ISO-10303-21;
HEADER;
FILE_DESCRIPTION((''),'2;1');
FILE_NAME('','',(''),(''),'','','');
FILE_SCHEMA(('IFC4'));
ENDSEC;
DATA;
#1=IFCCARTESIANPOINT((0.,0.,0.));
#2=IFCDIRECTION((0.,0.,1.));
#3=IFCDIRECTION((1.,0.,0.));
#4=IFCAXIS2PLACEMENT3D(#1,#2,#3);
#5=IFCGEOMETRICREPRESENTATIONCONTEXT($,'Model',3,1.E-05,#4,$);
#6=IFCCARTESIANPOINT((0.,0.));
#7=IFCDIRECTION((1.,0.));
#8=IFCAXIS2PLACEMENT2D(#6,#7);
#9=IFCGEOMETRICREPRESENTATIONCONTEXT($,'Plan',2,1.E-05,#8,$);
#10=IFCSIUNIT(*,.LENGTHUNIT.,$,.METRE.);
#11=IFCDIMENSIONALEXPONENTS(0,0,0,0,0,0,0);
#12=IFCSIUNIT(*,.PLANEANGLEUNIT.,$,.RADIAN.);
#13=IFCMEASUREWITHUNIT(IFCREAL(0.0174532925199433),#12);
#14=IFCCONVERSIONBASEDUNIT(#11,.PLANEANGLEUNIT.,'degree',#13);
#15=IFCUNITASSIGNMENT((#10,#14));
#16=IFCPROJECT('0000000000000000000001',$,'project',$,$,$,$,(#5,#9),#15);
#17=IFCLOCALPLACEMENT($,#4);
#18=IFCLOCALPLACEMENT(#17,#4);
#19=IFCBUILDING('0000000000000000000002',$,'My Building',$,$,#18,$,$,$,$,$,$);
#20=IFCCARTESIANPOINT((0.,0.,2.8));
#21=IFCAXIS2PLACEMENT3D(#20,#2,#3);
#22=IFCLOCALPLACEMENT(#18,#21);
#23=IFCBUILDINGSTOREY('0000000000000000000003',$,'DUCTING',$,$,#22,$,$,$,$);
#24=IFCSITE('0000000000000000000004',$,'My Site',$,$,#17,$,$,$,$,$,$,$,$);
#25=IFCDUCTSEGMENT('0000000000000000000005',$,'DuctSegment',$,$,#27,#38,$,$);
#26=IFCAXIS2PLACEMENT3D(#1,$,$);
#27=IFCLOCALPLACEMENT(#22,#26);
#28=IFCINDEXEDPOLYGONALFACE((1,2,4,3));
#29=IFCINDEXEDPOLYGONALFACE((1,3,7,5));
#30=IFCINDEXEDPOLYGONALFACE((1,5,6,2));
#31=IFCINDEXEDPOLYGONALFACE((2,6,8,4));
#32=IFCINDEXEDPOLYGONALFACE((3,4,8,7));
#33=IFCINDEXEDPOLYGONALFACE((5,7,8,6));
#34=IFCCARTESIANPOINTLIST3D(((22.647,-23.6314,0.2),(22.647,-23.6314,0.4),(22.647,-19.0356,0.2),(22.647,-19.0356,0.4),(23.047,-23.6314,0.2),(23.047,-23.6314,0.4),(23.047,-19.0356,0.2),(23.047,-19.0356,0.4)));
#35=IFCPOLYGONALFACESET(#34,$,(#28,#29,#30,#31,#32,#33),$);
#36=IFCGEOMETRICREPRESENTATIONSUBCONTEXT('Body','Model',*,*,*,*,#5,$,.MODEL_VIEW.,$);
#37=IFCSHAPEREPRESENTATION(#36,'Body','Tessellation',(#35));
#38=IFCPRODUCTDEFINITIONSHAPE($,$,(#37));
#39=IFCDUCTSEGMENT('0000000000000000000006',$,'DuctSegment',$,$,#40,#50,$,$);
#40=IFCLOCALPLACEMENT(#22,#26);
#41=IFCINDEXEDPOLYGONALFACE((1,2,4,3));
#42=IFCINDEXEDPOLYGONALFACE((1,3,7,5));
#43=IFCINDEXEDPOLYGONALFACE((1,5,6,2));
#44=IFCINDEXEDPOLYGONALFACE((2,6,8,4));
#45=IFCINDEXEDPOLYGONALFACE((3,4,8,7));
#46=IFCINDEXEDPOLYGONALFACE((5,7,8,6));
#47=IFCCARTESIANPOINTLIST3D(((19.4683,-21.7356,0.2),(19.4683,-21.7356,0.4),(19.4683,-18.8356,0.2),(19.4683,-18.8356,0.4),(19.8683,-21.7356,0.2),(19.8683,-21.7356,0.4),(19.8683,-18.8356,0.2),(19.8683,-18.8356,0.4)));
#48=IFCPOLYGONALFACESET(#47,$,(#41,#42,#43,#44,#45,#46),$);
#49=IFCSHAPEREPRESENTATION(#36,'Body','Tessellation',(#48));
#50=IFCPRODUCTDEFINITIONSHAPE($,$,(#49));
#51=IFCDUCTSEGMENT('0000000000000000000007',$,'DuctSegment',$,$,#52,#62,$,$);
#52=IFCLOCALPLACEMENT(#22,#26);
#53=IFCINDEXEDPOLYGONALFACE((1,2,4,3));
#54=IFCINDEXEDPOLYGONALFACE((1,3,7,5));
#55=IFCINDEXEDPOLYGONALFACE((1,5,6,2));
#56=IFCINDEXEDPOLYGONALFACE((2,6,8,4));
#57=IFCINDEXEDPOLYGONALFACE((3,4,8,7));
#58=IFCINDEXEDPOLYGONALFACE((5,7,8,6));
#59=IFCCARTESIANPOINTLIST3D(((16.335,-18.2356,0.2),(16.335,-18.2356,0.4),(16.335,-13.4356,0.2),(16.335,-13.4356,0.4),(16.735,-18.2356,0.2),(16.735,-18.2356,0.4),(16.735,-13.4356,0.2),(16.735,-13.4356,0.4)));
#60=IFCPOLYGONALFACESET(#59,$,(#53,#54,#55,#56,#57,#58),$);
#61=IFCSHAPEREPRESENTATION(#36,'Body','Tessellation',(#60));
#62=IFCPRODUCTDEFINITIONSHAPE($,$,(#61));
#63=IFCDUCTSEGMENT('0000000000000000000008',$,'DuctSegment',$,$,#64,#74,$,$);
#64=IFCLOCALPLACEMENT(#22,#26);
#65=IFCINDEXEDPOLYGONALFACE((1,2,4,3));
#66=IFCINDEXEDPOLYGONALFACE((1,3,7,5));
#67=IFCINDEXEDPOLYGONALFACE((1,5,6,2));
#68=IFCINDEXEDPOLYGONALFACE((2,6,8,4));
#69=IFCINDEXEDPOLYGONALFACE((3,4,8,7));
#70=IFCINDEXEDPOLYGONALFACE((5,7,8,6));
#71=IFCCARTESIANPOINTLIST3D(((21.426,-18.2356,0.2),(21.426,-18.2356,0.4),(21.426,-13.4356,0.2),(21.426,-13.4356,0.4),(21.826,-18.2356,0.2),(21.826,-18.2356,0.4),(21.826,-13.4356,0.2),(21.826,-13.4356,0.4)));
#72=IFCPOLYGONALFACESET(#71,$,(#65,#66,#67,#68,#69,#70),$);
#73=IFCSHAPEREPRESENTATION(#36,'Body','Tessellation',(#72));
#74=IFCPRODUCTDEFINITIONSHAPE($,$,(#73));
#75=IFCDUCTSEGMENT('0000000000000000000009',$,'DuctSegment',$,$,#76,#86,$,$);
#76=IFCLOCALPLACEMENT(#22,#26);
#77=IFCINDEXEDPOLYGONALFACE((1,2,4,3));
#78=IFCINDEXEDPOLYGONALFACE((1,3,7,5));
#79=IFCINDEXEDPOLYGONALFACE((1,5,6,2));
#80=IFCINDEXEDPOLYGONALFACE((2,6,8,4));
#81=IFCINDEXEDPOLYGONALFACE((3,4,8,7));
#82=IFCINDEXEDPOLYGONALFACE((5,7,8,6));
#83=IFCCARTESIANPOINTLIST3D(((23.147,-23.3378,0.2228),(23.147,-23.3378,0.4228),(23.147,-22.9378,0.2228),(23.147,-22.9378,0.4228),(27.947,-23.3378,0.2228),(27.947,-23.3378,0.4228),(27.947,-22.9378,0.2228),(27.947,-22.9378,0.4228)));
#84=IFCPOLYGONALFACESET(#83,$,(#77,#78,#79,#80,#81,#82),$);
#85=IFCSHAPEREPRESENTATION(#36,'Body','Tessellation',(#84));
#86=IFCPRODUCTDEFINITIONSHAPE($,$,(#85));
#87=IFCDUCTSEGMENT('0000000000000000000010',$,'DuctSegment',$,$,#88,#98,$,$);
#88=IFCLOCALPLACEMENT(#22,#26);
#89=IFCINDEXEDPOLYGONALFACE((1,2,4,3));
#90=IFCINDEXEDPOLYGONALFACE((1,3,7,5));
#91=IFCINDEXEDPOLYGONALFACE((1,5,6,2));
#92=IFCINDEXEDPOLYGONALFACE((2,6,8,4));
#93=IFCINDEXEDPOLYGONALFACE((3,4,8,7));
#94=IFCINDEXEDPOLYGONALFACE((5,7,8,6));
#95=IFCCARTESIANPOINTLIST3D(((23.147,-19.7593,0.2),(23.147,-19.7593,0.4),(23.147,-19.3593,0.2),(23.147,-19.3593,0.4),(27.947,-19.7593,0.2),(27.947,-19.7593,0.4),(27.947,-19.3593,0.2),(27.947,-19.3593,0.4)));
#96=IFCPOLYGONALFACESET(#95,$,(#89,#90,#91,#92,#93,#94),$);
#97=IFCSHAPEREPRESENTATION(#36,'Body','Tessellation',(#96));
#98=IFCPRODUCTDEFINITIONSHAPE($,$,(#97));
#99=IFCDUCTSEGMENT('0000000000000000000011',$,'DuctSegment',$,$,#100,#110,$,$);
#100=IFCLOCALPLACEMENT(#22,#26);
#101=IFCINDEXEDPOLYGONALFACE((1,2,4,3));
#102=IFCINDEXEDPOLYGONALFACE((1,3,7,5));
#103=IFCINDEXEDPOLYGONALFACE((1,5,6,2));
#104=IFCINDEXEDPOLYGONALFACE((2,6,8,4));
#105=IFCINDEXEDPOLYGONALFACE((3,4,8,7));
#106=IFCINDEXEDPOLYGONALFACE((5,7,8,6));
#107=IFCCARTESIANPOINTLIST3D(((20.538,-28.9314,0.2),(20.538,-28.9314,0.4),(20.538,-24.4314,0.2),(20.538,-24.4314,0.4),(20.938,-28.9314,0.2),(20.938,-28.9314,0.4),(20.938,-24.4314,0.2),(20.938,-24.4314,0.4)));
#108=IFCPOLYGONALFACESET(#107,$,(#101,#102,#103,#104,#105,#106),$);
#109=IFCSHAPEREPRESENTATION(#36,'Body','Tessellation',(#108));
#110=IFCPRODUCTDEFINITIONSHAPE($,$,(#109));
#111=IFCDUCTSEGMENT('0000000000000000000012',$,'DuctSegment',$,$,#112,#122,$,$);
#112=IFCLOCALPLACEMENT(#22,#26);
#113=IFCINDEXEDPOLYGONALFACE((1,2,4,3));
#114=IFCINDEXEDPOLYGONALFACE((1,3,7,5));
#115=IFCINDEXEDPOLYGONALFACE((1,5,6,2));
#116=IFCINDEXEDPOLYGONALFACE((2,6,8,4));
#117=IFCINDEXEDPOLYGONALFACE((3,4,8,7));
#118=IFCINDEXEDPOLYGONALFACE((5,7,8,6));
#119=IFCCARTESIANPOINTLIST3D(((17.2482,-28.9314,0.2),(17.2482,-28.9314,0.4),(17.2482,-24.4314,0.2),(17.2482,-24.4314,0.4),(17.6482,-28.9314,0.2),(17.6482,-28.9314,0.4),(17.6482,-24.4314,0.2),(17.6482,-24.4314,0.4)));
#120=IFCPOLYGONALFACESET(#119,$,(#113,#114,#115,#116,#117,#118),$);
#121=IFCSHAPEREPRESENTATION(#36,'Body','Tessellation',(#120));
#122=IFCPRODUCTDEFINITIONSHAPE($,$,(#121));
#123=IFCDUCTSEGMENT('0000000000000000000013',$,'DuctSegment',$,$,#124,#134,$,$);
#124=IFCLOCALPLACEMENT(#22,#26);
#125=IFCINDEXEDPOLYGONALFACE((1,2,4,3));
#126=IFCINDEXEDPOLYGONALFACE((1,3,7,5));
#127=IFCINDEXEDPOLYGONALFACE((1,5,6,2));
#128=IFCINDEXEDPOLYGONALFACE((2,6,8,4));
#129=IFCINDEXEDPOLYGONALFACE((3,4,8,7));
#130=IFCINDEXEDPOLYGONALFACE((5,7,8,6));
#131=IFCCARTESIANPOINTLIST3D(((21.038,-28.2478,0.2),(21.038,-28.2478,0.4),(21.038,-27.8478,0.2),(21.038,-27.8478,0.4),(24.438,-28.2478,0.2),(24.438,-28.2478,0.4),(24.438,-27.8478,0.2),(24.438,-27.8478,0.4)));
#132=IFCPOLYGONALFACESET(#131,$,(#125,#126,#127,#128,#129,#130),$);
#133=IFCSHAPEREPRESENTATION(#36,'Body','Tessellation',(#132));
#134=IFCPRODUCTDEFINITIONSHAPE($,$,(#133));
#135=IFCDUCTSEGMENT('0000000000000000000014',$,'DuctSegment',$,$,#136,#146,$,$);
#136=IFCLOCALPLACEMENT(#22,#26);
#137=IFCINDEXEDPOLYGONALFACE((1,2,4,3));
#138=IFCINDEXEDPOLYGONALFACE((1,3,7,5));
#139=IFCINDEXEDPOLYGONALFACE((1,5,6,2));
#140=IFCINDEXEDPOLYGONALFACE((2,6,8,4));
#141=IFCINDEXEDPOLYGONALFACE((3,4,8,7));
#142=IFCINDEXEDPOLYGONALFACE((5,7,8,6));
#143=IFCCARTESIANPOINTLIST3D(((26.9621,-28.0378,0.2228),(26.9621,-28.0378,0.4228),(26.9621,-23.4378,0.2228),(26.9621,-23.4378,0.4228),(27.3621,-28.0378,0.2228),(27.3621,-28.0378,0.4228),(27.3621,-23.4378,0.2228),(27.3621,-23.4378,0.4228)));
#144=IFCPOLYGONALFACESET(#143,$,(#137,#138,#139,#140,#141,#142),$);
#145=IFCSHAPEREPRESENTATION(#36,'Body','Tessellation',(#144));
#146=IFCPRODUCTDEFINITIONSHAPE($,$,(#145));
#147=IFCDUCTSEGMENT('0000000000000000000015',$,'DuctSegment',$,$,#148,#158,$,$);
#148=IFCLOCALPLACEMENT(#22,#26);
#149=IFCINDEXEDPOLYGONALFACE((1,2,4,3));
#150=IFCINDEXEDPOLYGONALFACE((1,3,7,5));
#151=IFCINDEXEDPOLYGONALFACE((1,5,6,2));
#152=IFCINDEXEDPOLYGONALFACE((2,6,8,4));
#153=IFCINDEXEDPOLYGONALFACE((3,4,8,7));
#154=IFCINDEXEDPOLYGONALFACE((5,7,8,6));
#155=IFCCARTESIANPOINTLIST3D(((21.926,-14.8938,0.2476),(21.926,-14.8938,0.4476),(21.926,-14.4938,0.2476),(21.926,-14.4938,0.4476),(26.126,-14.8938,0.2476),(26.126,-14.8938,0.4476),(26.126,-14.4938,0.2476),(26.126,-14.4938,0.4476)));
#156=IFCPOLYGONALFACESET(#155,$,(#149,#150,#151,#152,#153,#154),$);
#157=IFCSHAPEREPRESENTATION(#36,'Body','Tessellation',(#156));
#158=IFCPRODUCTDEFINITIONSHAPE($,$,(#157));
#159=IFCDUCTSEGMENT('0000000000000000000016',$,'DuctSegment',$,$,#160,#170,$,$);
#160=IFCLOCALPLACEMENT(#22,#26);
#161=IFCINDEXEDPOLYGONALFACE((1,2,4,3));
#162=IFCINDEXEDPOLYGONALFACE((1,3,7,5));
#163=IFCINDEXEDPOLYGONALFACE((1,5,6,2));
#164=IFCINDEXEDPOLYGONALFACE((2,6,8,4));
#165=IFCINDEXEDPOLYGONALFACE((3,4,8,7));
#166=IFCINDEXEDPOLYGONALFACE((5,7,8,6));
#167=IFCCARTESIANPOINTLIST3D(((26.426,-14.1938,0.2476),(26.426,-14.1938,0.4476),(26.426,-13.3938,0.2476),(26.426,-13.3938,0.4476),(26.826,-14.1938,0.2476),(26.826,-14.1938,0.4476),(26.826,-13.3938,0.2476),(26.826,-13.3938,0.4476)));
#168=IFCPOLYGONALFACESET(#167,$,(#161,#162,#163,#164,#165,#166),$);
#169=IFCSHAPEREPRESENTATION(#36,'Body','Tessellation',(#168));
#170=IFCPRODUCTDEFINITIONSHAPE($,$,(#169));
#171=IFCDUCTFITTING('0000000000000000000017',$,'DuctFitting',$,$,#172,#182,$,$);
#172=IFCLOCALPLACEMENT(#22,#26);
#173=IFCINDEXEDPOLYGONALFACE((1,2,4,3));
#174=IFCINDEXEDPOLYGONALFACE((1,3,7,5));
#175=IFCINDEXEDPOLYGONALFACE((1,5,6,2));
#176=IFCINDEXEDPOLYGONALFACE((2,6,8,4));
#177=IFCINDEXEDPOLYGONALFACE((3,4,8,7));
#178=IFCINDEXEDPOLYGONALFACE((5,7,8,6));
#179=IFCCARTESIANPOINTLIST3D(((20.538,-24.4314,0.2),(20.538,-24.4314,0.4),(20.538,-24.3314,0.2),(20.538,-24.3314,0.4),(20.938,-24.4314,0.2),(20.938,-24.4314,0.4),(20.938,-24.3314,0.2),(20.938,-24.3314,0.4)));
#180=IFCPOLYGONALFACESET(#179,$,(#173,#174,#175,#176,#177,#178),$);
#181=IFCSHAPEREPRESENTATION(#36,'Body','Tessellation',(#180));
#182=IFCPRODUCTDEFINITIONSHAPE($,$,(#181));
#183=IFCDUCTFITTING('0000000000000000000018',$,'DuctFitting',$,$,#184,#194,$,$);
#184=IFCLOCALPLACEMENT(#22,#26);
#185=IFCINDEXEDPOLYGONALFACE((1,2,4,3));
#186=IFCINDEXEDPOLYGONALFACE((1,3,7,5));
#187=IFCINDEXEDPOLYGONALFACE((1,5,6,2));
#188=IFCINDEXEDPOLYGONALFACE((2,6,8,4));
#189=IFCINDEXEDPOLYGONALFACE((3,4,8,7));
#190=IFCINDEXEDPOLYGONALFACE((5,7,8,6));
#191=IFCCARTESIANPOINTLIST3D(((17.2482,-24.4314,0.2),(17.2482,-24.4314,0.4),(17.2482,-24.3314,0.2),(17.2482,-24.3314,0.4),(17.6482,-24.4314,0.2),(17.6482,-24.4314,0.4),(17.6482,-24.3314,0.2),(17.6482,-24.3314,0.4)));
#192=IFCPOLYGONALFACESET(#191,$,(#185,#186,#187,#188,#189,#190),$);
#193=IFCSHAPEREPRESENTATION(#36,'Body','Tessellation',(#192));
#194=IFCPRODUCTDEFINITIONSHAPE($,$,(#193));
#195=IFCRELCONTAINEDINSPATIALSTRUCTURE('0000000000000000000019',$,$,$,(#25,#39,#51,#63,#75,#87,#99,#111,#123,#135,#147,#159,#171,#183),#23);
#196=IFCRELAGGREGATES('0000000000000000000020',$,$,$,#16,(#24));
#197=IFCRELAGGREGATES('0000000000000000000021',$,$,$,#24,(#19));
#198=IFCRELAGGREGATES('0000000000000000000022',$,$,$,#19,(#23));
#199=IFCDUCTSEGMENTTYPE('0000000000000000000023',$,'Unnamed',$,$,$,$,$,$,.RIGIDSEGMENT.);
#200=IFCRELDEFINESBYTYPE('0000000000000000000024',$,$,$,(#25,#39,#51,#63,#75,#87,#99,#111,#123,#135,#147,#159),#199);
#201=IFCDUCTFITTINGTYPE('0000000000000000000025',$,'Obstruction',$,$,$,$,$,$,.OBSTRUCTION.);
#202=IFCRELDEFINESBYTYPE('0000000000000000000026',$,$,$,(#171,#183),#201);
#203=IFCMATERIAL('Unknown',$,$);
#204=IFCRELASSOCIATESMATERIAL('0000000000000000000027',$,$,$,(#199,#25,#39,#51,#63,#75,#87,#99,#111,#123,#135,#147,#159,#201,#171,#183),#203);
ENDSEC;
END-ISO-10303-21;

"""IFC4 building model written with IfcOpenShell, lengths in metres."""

from ifc_helpers import new_model, entity, si_unit, converted_unit, frame, origin_with_axes, origin_2d_with_axis, place, context, subcontext, project, spatial, rectangle, extrude, material, material_profile, profile_set, profile_usage, type_object, element, save


model = new_model("IFC4")

# Units and contexts
model_context = context("Model", 3, precision=1e-05, world=origin_with_axes())
plan_context = context("Plan", 2, precision=1e-05, world=origin_2d_with_axis())
body_context = subcontext(model_context, "Body", "Model", "MODEL_VIEW")
ifc_project = project(units=[si_unit("LENGTHUNIT", "METRE"), converted_unit("PLANEANGLEUNIT", "degree", entity("IfcReal", 0.0174532925199433), si_unit("PLANEANGLEUNIT", "RADIAN"), dimensions=[0, 0, 0, 0, 0, 0, 0])], contexts=[model_context, plan_context])

# Site, building, storey
site_placement = place(None, origin_with_axes())
site = spatial("IfcSite", under=ifc_project, at=site_placement, Name="My Site")
building_placement = place(site_placement, origin_with_axes())
building = spatial("IfcBuilding", under=site, at=building_placement, Name="My Building")
storey_placement = place(building_placement, frame((0.0, 0.0, 2.8), z_axis=(0.0, 0.0, 1.0), x_axis=(1.0, 0.0, 0.0)))
storey = spatial("IfcBuildingStorey", under=building, at=storey_placement, Name="DUCTING")

# Duct segments
ifc_material = material(Name="Unknown")
ifc_material_profile_1 = material_profile(ifc_material, rectangle(XDim=0.4, YDim=0.2))
ifc_profile_set_1 = profile_set([ifc_material_profile_1])
ifc_profile_usage_1 = profile_usage(ifc_profile_set_1, cardinal=5)
duct_segment_type = type_object("IfcDuctSegmentType", Name="Unnamed", PredefinedType="RIGIDSEGMENT", material=ifc_profile_set_1)
duct_segment_1_placement = place(storey_placement, frame((22.847, -19.0356, 0.3), z_axis=(0.0, -1.0, -0.000001), x_axis=(1.0, 0.0, 0.0)))
element("IfcDuctSegment", 1, at=duct_segment_1_placement, inside=storey, type_object=duct_segment_type, material=ifc_profile_usage_1, Name="DuctSegment", context=body_context, shape_type="SweptSolid", body=[
    extrude(rectangle(XDim=0.4, YDim=0.2), origin_with_axes(), (0.0, 0.0, 1.0), 4.5959),
])
ifc_profile_usage_2 = profile_usage(ifc_profile_set_1, cardinal=5)
duct_segment_2_placement = place(storey_placement, frame((19.6683, -18.8356, 0.3), z_axis=(0.0, -1.0, 0.0), x_axis=(1.0, 0.0, 0.0)))
element("IfcDuctSegment", 2, at=duct_segment_2_placement, inside=storey, type_object=duct_segment_type, material=ifc_profile_usage_2, Name="DuctSegment", context=body_context, shape_type="SweptSolid", body=[
    extrude(rectangle(XDim=0.4, YDim=0.2), origin_with_axes(), (0.0, 0.0, 1.0), 2.9),
])
ifc_profile_usage_3 = profile_usage(ifc_profile_set_1, cardinal=5)
duct_segment_3_placement = place(storey_placement, frame((16.535, -13.4356, 0.3), z_axis=(0.0, -1.0, 0.0), x_axis=(1.0, 0.0, 0.0)))
element("IfcDuctSegment", 3, at=duct_segment_3_placement, inside=storey, type_object=duct_segment_type, material=ifc_profile_usage_3, Name="DuctSegment", context=body_context, shape_type="SweptSolid", body=[
    extrude(rectangle(XDim=0.4, YDim=0.2), origin_with_axes(), (0.0, 0.0, 1.0), 4.8),
])
ifc_profile_usage_4 = profile_usage(ifc_profile_set_1, cardinal=5)
duct_segment_4_placement = place(storey_placement, frame((21.626, -13.4356, 0.3), z_axis=(0.0, -1.0, 0.0), x_axis=(1.0, 0.0, 0.0)))
element("IfcDuctSegment", 4, at=duct_segment_4_placement, inside=storey, type_object=duct_segment_type, material=ifc_profile_usage_4, Name="DuctSegment", context=body_context, shape_type="SweptSolid", body=[
    extrude(rectangle(XDim=0.4, YDim=0.2), origin_with_axes(), (0.0, 0.0, 1.0), 4.8),
])
ifc_profile_usage_5 = profile_usage(ifc_profile_set_1, cardinal=5)
duct_segment_5_placement = place(storey_placement, frame((23.147, -23.1378, 0.3228), z_axis=(1.0, 0.0, 0.0), x_axis=(0.0, 1.0, 0.0)))
element("IfcDuctSegment", 5, at=duct_segment_5_placement, inside=storey, type_object=duct_segment_type, material=ifc_profile_usage_5, Name="DuctSegment", context=body_context, shape_type="SweptSolid", body=[
    extrude(rectangle(XDim=0.4, YDim=0.2), origin_with_axes(), (0.0, 0.0, 1.0), 4.8),
])
ifc_profile_usage_6 = profile_usage(ifc_profile_set_1, cardinal=5)
duct_segment_6_placement = place(storey_placement, frame((23.147, -19.5593, 0.3), z_axis=(1.0, 0.0, 0.0), x_axis=(0.0, 1.0, 0.0)))
element("IfcDuctSegment", 6, at=duct_segment_6_placement, inside=storey, type_object=duct_segment_type, material=ifc_profile_usage_6, Name="DuctSegment", context=body_context, shape_type="SweptSolid", body=[
    extrude(rectangle(XDim=0.4, YDim=0.2), origin_with_axes(), (0.0, 0.0, 1.0), 4.8),
])
ifc_profile_usage_7 = profile_usage(ifc_profile_set_1, cardinal=5)
duct_segment_7_placement = place(storey_placement, frame((20.738, -24.4314, 0.3), z_axis=(0.0, -1.0, 0.0), x_axis=(1.0, 0.0, 0.0)))
element("IfcDuctSegment", 7, at=duct_segment_7_placement, inside=storey, type_object=duct_segment_type, material=ifc_profile_usage_7, Name="DuctSegment", context=body_context, shape_type="SweptSolid", body=[
    extrude(rectangle(XDim=0.4, YDim=0.2), origin_with_axes(), (0.0, 0.0, 1.0), 4.5),
])
ifc_profile_usage_8 = profile_usage(ifc_profile_set_1, cardinal=5)
duct_segment_8_placement = place(storey_placement, frame((17.4482, -24.4314, 0.3), z_axis=(0.0, -1.0, 0.0), x_axis=(1.0, 0.0, 0.0)))
element("IfcDuctSegment", 8, at=duct_segment_8_placement, inside=storey, type_object=duct_segment_type, material=ifc_profile_usage_8, Name="DuctSegment", context=body_context, shape_type="SweptSolid", body=[
    extrude(rectangle(XDim=0.4, YDim=0.2), origin_with_axes(), (0.0, 0.0, 1.0), 4.5),
])
ifc_profile_usage_9 = profile_usage(ifc_profile_set_1, cardinal=5)
duct_segment_9_placement = place(storey_placement, frame((21.038, -28.0478, 0.3), z_axis=(1.0, 0.0, 0.0), x_axis=(0.0, 1.0, 0.0)))
element("IfcDuctSegment", 9, at=duct_segment_9_placement, inside=storey, type_object=duct_segment_type, material=ifc_profile_usage_9, Name="DuctSegment", context=body_context, shape_type="SweptSolid", body=[
    extrude(rectangle(XDim=0.4, YDim=0.2), origin_with_axes(), (0.0, 0.0, 1.0), 3.4),
])
ifc_profile_usage_10 = profile_usage(ifc_profile_set_1, cardinal=5)
duct_segment_10_placement = place(storey_placement, frame((27.1621, -23.4378, 0.3228), z_axis=(0.0, -1.0, 0.0), x_axis=(1.0, 0.0, 0.0)))
element("IfcDuctSegment", 10, at=duct_segment_10_placement, inside=storey, type_object=duct_segment_type, material=ifc_profile_usage_10, Name="DuctSegment", context=body_context, shape_type="SweptSolid", body=[
    extrude(rectangle(XDim=0.4, YDim=0.2), origin_with_axes(), (0.0, 0.0, 1.0), 4.6),
])
ifc_profile_usage_11 = profile_usage(ifc_profile_set_1, cardinal=5)
duct_segment_11_placement = place(storey_placement, frame((21.926, -14.6938, 0.3476), z_axis=(1.0, 0.0, 0.0), x_axis=(0.0, 1.0, 0.0)))
element("IfcDuctSegment", 11, at=duct_segment_11_placement, inside=storey, type_object=duct_segment_type, material=ifc_profile_usage_11, Name="DuctSegment", context=body_context, shape_type="SweptSolid", body=[
    extrude(rectangle(XDim=0.4, YDim=0.2), origin_with_axes(), (0.0, 0.0, 1.0), 4.2),
])
ifc_profile_usage_12 = profile_usage(ifc_profile_set_1, cardinal=5)
duct_segment_12_placement = place(storey_placement, frame((26.626, -14.1938, 0.3476), z_axis=(0.0, 1.0, 0.0), x_axis=(-1.0, 0.0, 0.0)))
element("IfcDuctSegment", 12, at=duct_segment_12_placement, inside=storey, type_object=duct_segment_type, material=ifc_profile_usage_12, Name="DuctSegment", context=body_context, shape_type="SweptSolid", body=[
    extrude(rectangle(XDim=0.4, YDim=0.2), origin_with_axes(), (0.0, 0.0, 1.0), 0.8),
])

# Duct fittings
ifc_material_profile_2 = material_profile(ifc_material, rectangle(XDim=0.4, YDim=0.2))
ifc_profile_set_2 = profile_set([ifc_material_profile_2])
ifc_profile_usage_13 = profile_usage(ifc_profile_set_2, cardinal=5)
duct_fitting_type_1 = type_object("IfcDuctFittingType", Name="Obstruction", PredefinedType="OBSTRUCTION", material=ifc_profile_set_2)
duct_fitting_1_placement = place(storey_placement, frame((20.738, -24.3314, 0.3), z_axis=(0.0, -1.0, 0.0), x_axis=(1.0, 0.0, 0.0)))
element("IfcDuctFitting", 13, at=duct_fitting_1_placement, inside=storey, type_object=duct_fitting_type_1, material=ifc_profile_usage_13, Name="DuctFitting", context=body_context, shape_type="SweptSolid", body=[
    extrude(rectangle(XDim=0.4, YDim=0.2), origin_with_axes(), (0.0, 0.0, 1.0), 0.1),
])
ifc_profile_usage_14 = profile_usage(ifc_profile_set_2, cardinal=5)
duct_fitting_2_placement = place(storey_placement, frame((17.4482, -24.3314, 0.3), z_axis=(0.0, -1.0, 0.0), x_axis=(1.0, 0.0, 0.0)))
element("IfcDuctFitting", 14, at=duct_fitting_2_placement, inside=storey, type_object=duct_fitting_type_1, material=ifc_profile_usage_14, Name="DuctFitting", context=body_context, shape_type="SweptSolid", body=[
    extrude(rectangle(XDim=0.4, YDim=0.2), origin_with_axes(), (0.0, 0.0, 1.0), 0.1),
])

save(model, "model.ifc")
